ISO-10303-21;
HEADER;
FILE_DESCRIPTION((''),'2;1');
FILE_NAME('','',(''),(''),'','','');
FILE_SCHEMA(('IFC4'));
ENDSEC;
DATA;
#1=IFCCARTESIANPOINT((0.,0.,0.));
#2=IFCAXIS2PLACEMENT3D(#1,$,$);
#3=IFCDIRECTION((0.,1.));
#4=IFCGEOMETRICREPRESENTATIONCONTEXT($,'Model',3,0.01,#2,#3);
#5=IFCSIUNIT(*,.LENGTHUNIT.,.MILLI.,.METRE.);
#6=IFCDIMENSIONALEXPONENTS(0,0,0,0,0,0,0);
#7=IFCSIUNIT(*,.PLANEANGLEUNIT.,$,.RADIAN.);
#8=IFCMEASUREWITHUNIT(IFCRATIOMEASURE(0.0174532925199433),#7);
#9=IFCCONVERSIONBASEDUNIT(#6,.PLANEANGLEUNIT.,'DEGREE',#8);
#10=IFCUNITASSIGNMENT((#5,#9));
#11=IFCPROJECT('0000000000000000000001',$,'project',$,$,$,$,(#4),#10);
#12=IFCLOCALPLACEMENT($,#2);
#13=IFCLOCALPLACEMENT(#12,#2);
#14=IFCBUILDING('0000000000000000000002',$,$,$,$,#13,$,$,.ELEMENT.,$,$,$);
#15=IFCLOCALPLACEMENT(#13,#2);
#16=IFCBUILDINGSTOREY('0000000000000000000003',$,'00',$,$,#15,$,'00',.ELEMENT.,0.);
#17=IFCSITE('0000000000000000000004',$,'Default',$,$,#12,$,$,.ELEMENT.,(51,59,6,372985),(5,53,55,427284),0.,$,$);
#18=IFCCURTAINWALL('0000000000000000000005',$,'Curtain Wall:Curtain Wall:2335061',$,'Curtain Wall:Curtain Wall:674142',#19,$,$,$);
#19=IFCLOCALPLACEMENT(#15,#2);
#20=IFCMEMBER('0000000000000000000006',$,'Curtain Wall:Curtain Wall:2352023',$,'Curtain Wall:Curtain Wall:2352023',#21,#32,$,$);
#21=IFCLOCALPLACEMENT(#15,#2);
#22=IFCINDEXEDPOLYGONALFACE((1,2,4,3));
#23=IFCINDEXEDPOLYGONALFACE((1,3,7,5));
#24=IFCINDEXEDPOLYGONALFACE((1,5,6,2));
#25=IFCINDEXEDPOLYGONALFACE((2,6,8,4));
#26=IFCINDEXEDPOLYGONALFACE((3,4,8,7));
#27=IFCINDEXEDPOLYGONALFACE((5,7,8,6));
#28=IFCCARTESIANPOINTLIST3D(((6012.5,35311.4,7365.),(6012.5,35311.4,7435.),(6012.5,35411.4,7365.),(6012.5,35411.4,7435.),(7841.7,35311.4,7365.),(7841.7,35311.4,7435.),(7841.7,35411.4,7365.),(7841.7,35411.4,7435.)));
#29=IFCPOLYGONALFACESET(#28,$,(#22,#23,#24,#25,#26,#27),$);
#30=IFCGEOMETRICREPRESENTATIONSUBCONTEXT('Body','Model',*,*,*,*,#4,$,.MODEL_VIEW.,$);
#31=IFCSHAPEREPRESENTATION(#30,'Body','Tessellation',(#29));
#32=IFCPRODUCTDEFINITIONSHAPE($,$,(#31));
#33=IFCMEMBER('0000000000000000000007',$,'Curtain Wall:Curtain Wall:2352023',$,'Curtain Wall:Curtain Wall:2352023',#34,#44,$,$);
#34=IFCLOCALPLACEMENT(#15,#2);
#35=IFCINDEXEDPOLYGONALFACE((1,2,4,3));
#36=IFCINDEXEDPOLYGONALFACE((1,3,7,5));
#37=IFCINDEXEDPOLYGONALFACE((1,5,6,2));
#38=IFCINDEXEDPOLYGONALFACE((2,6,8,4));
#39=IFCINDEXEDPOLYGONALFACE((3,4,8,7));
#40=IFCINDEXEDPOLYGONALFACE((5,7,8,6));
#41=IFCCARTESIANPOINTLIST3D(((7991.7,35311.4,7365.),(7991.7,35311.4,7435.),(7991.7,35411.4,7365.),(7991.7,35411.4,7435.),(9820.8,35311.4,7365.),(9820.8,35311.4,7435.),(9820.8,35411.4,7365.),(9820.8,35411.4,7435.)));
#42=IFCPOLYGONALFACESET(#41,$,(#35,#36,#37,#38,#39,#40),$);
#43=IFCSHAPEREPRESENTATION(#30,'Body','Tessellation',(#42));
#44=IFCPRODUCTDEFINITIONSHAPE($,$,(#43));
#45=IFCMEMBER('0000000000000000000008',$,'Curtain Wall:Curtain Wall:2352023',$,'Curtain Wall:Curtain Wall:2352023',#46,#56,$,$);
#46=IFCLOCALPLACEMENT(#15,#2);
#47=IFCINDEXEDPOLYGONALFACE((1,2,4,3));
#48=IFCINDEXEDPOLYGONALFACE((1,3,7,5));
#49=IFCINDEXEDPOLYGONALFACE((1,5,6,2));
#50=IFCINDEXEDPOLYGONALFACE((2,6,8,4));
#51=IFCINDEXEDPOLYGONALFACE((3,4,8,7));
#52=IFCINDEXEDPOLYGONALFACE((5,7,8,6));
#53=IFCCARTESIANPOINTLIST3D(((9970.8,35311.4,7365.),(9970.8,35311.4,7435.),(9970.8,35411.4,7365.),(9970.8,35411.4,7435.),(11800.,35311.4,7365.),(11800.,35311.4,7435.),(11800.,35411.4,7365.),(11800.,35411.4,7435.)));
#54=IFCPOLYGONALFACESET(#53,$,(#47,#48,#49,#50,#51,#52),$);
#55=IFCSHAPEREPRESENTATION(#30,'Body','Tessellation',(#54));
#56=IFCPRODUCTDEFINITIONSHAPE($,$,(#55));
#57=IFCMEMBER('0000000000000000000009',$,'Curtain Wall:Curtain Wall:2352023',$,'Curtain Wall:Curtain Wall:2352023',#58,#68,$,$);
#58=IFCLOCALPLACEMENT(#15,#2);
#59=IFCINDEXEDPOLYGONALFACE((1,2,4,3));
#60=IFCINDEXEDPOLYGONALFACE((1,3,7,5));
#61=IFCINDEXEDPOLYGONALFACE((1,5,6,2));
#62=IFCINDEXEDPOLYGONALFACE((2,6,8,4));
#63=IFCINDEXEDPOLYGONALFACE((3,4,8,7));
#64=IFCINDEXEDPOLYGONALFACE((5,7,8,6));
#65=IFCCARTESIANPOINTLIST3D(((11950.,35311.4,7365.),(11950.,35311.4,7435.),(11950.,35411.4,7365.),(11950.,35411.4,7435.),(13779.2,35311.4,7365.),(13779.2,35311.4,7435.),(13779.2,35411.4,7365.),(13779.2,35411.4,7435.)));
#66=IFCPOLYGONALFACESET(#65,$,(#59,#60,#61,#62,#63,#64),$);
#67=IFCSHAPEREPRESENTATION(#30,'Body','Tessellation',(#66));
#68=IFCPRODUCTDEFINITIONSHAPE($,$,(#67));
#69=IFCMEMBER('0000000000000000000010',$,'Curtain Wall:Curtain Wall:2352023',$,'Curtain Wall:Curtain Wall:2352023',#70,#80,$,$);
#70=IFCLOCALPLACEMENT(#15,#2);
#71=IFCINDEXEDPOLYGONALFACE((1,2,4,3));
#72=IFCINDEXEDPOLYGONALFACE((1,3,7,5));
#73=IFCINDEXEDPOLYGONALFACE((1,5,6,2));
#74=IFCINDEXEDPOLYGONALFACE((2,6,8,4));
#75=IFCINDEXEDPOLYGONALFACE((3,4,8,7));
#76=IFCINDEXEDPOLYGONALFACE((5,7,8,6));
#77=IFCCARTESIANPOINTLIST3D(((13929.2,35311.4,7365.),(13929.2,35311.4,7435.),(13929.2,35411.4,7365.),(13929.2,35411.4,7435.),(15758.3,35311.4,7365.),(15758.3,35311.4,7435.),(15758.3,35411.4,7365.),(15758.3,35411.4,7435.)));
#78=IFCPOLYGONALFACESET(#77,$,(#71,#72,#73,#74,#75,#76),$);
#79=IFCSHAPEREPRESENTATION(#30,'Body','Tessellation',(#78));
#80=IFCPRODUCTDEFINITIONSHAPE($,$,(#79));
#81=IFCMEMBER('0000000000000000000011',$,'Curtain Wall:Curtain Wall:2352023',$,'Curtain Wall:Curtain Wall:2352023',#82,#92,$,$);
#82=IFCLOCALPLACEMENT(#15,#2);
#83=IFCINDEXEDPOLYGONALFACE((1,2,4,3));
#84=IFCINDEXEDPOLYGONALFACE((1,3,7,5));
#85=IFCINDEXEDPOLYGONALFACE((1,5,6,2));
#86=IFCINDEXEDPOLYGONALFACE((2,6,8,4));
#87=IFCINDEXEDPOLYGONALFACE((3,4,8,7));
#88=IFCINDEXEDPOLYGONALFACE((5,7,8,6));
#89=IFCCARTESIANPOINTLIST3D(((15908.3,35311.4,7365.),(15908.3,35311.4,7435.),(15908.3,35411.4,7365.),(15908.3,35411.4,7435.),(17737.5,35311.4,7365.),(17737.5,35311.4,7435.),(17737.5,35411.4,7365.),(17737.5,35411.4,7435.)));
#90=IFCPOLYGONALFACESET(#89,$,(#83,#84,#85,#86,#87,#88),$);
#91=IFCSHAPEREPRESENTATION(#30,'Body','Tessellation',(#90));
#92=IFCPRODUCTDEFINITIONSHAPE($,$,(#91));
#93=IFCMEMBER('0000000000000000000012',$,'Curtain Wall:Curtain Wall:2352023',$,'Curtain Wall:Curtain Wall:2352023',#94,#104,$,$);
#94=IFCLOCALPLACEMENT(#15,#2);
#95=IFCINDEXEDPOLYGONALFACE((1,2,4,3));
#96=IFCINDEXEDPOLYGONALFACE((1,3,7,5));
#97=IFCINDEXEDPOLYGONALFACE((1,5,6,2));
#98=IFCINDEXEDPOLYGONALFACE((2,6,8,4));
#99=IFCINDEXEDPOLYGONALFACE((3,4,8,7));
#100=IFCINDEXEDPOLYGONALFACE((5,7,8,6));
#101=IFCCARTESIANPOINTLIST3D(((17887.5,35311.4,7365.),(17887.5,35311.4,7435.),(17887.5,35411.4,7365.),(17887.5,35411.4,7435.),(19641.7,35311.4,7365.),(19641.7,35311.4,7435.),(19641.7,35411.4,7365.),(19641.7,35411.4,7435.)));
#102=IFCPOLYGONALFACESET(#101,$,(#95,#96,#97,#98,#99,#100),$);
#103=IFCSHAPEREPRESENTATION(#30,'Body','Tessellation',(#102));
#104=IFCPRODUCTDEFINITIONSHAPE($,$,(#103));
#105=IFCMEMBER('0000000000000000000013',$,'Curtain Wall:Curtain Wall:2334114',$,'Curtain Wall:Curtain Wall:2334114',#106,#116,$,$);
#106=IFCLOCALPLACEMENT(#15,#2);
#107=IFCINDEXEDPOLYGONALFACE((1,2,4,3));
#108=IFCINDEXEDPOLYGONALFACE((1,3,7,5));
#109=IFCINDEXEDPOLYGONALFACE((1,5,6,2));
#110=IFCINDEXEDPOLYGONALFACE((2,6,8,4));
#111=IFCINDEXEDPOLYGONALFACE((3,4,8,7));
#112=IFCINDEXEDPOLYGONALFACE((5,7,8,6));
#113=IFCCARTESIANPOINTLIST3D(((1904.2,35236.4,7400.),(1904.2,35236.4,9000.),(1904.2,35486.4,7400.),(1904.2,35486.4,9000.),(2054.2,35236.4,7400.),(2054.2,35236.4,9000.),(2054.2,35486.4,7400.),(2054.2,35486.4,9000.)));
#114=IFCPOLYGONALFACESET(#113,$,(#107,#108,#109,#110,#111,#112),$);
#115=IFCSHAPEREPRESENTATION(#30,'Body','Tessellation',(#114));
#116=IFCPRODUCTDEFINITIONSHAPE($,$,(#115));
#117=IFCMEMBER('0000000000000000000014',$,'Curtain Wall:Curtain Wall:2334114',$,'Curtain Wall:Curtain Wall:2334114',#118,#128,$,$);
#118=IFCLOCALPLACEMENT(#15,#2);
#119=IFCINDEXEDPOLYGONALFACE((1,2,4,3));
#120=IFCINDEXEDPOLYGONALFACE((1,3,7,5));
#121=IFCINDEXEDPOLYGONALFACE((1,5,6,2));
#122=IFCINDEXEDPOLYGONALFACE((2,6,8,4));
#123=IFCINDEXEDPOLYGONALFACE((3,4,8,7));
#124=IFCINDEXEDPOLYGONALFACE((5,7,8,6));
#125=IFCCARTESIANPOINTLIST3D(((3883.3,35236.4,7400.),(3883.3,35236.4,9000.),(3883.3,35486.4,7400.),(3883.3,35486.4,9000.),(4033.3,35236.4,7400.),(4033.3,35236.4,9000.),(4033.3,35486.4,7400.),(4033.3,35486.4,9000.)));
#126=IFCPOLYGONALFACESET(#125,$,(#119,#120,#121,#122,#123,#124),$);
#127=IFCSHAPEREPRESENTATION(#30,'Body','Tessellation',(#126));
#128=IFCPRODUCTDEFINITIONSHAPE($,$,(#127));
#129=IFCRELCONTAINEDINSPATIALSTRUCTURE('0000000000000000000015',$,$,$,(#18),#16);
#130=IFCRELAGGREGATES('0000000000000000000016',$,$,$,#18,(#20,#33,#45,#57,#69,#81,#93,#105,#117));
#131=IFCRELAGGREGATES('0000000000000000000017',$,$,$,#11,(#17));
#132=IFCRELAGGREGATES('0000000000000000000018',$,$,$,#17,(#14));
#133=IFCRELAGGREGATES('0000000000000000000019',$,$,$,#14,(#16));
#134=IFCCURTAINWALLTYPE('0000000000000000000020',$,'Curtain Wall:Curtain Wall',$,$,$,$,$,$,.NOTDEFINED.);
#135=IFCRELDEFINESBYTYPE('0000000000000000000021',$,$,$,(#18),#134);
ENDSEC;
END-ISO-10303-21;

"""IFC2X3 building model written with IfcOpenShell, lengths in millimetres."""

from ifc_helpers import new_model, entity, si_unit, converted_unit, direction, frame, frame_2d, origin, place, context, subcontext, project, spatial, rectangle, extrude, type_object, element, aggregate, save


model = new_model("IFC2X3")

# Units and contexts
model_context = context("Model", 3, precision=0.01, world=origin(), true_north=direction((0.0, 1.0)))
body_context = subcontext(model_context, "Body", "Model", "MODEL_VIEW")
ifc_project = project(units=[si_unit("LENGTHUNIT", "METRE", prefix="MILLI"), converted_unit("PLANEANGLEUNIT", "DEGREE", entity("IfcRatioMeasure", 0.0174532925199433), si_unit("PLANEANGLEUNIT", "RADIAN"), dimensions=[0, 0, 0, 0, 0, 0, 0])], contexts=[model_context])

# Site, building, storey
site_placement = place(None, origin())
site = spatial("IfcSite", under=ifc_project, at=site_placement, Name="Default", CompositionType="ELEMENT", RefLatitude=(51, 59, 6, 372985), RefLongitude=(5, 53, 55, 427284), RefElevation=0.0)
building_placement = place(site_placement, origin())
building = spatial("IfcBuilding", under=site, at=building_placement, CompositionType="ELEMENT")
storey_placement = place(building_placement, origin())
storey = spatial("IfcBuildingStorey", under=building, at=storey_placement, Name="00", LongName="00", CompositionType="ELEMENT", Elevation=0.0)

# Curtain wall, members
curtain_wall_type = type_object("IfcCurtainWallType", Name="Curtain Wall:Curtain Wall", PredefinedType="NOTDEFINED")
curtain_wall_placement = place(storey_placement, origin())
curtain_wall = element("IfcCurtainWall", 1, at=curtain_wall_placement, inside=storey, type_object=curtain_wall_type, Name="Curtain Wall:Curtain Wall:2335061", ObjectType="Curtain Wall:Curtain Wall:674142")
member_1_placement = place(curtain_wall_placement, origin())
member_1 = element("IfcMember", 2, at=member_1_placement, Name="Curtain Wall:Curtain Wall:2352023", ObjectType="Curtain Wall:Curtain Wall:2352023", context=body_context, shape_type="SweptSolid", body=[
    extrude(rectangle(XDim=70.0, YDim=100.0, at=frame_2d((0.0, 0.0), x_axis=(1.0, 0.0))), frame((7841.7, 35361.4, 7400.0), z_axis=(-1.0, 0.0, 0.0), x_axis=(0.0, 0.0, -1.0)), (0.0, 0.0, 1.0), 1829.2),
])
member_2_placement = place(curtain_wall_placement, origin())
member_2 = element("IfcMember", 3, at=member_2_placement, Name="Curtain Wall:Curtain Wall:2352023", ObjectType="Curtain Wall:Curtain Wall:2352023", context=body_context, shape_type="SweptSolid", body=[
    extrude(rectangle(XDim=70.0, YDim=100.0, at=frame_2d((0.0, 0.0), x_axis=(1.0, 0.0))), frame((9820.8, 35361.4, 7400.0), z_axis=(-1.0, 0.0, 0.0), x_axis=(0.0, 0.0, -1.0)), (0.0, 0.0, 1.0), 1829.2),
])
member_3_placement = place(curtain_wall_placement, origin())
member_3 = element("IfcMember", 4, at=member_3_placement, Name="Curtain Wall:Curtain Wall:2352023", ObjectType="Curtain Wall:Curtain Wall:2352023", context=body_context, shape_type="SweptSolid", body=[
    extrude(rectangle(XDim=70.0, YDim=100.0, at=frame_2d((0.0, 0.0), x_axis=(1.0, 0.0))), frame((11800.0, 35361.4, 7400.0), z_axis=(-1.0, 0.0, 0.0), x_axis=(0.0, 0.0, -1.0)), (0.0, 0.0, 1.0), 1829.2),
])
member_4_placement = place(curtain_wall_placement, origin())
member_4 = element("IfcMember", 5, at=member_4_placement, Name="Curtain Wall:Curtain Wall:2352023", ObjectType="Curtain Wall:Curtain Wall:2352023", context=body_context, shape_type="SweptSolid", body=[
    extrude(rectangle(XDim=70.0, YDim=100.0, at=frame_2d((0.0, 0.0), x_axis=(1.0, 0.0))), frame((13779.2, 35361.4, 7400.0), z_axis=(-1.0, 0.0, 0.0), x_axis=(0.0, 0.0, -1.0)), (0.0, 0.0, 1.0), 1829.2),
])
member_5_placement = place(curtain_wall_placement, origin())
member_5 = element("IfcMember", 6, at=member_5_placement, Name="Curtain Wall:Curtain Wall:2352023", ObjectType="Curtain Wall:Curtain Wall:2352023", context=body_context, shape_type="SweptSolid", body=[
    extrude(rectangle(XDim=70.0, YDim=100.0, at=frame_2d((0.0, 0.0), x_axis=(1.0, 0.0))), frame((15758.3, 35361.4, 7400.0), z_axis=(-1.0, 0.0, 0.0), x_axis=(0.0, 0.0, -1.0)), (0.0, 0.0, 1.0), 1829.2),
])
member_6_placement = place(curtain_wall_placement, origin())
member_6 = element("IfcMember", 7, at=member_6_placement, Name="Curtain Wall:Curtain Wall:2352023", ObjectType="Curtain Wall:Curtain Wall:2352023", context=body_context, shape_type="SweptSolid", body=[
    extrude(rectangle(XDim=70.0, YDim=100.0, at=frame_2d((0.0, 0.0), x_axis=(1.0, 0.0))), frame((17737.5, 35361.4, 7400.0), z_axis=(-1.0, 0.0, 0.0), x_axis=(0.0, 0.0, -1.0)), (0.0, 0.0, 1.0), 1829.2),
])
member_7_placement = place(curtain_wall_placement, origin())
member_7 = element("IfcMember", 8, at=member_7_placement, Name="Curtain Wall:Curtain Wall:2352023", ObjectType="Curtain Wall:Curtain Wall:2352023", context=body_context, shape_type="SweptSolid", body=[
    extrude(rectangle(XDim=70.0, YDim=100.0, at=frame_2d((0.0, 0.0), x_axis=(1.0, 0.0))), frame((19641.7, 35361.4, 7400.0), z_axis=(-1.0, 0.0, 0.0), x_axis=(0.0, 0.0, -1.0)), (0.0, 0.0, 1.0), 1754.2),
])
member_8_placement = place(curtain_wall_placement, origin())
member_8 = element("IfcMember", 9, at=member_8_placement, Name="Curtain Wall:Curtain Wall:2334114", ObjectType="Curtain Wall:Curtain Wall:2334114", context=body_context, shape_type="SweptSolid", body=[
    extrude(rectangle(XDim=150.0, YDim=250.0, at=frame_2d((0.0, 0.0), x_axis=(1.0, 0.0))), frame((1979.2, 35361.4, 7400.0), z_axis=(0.0, 0.0, 1.0), x_axis=(-1.0, 0.0, 0.0)), (0.0, 0.0, 1.0), 1600.0),
])
member_9_placement = place(curtain_wall_placement, origin())
member_9 = element("IfcMember", 10, at=member_9_placement, Name="Curtain Wall:Curtain Wall:2334114", ObjectType="Curtain Wall:Curtain Wall:2334114", context=body_context, shape_type="SweptSolid", body=[
    extrude(rectangle(XDim=150.0, YDim=250.0, at=frame_2d((0.0, 0.0), x_axis=(1.0, 0.0))), frame((3958.3, 35361.4, 7400.0), z_axis=(0.0, 0.0, 1.0), x_axis=(-1.0, 0.0, 0.0)), (0.0, 0.0, 1.0), 1600.0),
])
aggregate(curtain_wall, [member_1, member_2, member_3, member_4, member_5, member_6, member_7, member_8, member_9])

save(model, "model.ifc")
